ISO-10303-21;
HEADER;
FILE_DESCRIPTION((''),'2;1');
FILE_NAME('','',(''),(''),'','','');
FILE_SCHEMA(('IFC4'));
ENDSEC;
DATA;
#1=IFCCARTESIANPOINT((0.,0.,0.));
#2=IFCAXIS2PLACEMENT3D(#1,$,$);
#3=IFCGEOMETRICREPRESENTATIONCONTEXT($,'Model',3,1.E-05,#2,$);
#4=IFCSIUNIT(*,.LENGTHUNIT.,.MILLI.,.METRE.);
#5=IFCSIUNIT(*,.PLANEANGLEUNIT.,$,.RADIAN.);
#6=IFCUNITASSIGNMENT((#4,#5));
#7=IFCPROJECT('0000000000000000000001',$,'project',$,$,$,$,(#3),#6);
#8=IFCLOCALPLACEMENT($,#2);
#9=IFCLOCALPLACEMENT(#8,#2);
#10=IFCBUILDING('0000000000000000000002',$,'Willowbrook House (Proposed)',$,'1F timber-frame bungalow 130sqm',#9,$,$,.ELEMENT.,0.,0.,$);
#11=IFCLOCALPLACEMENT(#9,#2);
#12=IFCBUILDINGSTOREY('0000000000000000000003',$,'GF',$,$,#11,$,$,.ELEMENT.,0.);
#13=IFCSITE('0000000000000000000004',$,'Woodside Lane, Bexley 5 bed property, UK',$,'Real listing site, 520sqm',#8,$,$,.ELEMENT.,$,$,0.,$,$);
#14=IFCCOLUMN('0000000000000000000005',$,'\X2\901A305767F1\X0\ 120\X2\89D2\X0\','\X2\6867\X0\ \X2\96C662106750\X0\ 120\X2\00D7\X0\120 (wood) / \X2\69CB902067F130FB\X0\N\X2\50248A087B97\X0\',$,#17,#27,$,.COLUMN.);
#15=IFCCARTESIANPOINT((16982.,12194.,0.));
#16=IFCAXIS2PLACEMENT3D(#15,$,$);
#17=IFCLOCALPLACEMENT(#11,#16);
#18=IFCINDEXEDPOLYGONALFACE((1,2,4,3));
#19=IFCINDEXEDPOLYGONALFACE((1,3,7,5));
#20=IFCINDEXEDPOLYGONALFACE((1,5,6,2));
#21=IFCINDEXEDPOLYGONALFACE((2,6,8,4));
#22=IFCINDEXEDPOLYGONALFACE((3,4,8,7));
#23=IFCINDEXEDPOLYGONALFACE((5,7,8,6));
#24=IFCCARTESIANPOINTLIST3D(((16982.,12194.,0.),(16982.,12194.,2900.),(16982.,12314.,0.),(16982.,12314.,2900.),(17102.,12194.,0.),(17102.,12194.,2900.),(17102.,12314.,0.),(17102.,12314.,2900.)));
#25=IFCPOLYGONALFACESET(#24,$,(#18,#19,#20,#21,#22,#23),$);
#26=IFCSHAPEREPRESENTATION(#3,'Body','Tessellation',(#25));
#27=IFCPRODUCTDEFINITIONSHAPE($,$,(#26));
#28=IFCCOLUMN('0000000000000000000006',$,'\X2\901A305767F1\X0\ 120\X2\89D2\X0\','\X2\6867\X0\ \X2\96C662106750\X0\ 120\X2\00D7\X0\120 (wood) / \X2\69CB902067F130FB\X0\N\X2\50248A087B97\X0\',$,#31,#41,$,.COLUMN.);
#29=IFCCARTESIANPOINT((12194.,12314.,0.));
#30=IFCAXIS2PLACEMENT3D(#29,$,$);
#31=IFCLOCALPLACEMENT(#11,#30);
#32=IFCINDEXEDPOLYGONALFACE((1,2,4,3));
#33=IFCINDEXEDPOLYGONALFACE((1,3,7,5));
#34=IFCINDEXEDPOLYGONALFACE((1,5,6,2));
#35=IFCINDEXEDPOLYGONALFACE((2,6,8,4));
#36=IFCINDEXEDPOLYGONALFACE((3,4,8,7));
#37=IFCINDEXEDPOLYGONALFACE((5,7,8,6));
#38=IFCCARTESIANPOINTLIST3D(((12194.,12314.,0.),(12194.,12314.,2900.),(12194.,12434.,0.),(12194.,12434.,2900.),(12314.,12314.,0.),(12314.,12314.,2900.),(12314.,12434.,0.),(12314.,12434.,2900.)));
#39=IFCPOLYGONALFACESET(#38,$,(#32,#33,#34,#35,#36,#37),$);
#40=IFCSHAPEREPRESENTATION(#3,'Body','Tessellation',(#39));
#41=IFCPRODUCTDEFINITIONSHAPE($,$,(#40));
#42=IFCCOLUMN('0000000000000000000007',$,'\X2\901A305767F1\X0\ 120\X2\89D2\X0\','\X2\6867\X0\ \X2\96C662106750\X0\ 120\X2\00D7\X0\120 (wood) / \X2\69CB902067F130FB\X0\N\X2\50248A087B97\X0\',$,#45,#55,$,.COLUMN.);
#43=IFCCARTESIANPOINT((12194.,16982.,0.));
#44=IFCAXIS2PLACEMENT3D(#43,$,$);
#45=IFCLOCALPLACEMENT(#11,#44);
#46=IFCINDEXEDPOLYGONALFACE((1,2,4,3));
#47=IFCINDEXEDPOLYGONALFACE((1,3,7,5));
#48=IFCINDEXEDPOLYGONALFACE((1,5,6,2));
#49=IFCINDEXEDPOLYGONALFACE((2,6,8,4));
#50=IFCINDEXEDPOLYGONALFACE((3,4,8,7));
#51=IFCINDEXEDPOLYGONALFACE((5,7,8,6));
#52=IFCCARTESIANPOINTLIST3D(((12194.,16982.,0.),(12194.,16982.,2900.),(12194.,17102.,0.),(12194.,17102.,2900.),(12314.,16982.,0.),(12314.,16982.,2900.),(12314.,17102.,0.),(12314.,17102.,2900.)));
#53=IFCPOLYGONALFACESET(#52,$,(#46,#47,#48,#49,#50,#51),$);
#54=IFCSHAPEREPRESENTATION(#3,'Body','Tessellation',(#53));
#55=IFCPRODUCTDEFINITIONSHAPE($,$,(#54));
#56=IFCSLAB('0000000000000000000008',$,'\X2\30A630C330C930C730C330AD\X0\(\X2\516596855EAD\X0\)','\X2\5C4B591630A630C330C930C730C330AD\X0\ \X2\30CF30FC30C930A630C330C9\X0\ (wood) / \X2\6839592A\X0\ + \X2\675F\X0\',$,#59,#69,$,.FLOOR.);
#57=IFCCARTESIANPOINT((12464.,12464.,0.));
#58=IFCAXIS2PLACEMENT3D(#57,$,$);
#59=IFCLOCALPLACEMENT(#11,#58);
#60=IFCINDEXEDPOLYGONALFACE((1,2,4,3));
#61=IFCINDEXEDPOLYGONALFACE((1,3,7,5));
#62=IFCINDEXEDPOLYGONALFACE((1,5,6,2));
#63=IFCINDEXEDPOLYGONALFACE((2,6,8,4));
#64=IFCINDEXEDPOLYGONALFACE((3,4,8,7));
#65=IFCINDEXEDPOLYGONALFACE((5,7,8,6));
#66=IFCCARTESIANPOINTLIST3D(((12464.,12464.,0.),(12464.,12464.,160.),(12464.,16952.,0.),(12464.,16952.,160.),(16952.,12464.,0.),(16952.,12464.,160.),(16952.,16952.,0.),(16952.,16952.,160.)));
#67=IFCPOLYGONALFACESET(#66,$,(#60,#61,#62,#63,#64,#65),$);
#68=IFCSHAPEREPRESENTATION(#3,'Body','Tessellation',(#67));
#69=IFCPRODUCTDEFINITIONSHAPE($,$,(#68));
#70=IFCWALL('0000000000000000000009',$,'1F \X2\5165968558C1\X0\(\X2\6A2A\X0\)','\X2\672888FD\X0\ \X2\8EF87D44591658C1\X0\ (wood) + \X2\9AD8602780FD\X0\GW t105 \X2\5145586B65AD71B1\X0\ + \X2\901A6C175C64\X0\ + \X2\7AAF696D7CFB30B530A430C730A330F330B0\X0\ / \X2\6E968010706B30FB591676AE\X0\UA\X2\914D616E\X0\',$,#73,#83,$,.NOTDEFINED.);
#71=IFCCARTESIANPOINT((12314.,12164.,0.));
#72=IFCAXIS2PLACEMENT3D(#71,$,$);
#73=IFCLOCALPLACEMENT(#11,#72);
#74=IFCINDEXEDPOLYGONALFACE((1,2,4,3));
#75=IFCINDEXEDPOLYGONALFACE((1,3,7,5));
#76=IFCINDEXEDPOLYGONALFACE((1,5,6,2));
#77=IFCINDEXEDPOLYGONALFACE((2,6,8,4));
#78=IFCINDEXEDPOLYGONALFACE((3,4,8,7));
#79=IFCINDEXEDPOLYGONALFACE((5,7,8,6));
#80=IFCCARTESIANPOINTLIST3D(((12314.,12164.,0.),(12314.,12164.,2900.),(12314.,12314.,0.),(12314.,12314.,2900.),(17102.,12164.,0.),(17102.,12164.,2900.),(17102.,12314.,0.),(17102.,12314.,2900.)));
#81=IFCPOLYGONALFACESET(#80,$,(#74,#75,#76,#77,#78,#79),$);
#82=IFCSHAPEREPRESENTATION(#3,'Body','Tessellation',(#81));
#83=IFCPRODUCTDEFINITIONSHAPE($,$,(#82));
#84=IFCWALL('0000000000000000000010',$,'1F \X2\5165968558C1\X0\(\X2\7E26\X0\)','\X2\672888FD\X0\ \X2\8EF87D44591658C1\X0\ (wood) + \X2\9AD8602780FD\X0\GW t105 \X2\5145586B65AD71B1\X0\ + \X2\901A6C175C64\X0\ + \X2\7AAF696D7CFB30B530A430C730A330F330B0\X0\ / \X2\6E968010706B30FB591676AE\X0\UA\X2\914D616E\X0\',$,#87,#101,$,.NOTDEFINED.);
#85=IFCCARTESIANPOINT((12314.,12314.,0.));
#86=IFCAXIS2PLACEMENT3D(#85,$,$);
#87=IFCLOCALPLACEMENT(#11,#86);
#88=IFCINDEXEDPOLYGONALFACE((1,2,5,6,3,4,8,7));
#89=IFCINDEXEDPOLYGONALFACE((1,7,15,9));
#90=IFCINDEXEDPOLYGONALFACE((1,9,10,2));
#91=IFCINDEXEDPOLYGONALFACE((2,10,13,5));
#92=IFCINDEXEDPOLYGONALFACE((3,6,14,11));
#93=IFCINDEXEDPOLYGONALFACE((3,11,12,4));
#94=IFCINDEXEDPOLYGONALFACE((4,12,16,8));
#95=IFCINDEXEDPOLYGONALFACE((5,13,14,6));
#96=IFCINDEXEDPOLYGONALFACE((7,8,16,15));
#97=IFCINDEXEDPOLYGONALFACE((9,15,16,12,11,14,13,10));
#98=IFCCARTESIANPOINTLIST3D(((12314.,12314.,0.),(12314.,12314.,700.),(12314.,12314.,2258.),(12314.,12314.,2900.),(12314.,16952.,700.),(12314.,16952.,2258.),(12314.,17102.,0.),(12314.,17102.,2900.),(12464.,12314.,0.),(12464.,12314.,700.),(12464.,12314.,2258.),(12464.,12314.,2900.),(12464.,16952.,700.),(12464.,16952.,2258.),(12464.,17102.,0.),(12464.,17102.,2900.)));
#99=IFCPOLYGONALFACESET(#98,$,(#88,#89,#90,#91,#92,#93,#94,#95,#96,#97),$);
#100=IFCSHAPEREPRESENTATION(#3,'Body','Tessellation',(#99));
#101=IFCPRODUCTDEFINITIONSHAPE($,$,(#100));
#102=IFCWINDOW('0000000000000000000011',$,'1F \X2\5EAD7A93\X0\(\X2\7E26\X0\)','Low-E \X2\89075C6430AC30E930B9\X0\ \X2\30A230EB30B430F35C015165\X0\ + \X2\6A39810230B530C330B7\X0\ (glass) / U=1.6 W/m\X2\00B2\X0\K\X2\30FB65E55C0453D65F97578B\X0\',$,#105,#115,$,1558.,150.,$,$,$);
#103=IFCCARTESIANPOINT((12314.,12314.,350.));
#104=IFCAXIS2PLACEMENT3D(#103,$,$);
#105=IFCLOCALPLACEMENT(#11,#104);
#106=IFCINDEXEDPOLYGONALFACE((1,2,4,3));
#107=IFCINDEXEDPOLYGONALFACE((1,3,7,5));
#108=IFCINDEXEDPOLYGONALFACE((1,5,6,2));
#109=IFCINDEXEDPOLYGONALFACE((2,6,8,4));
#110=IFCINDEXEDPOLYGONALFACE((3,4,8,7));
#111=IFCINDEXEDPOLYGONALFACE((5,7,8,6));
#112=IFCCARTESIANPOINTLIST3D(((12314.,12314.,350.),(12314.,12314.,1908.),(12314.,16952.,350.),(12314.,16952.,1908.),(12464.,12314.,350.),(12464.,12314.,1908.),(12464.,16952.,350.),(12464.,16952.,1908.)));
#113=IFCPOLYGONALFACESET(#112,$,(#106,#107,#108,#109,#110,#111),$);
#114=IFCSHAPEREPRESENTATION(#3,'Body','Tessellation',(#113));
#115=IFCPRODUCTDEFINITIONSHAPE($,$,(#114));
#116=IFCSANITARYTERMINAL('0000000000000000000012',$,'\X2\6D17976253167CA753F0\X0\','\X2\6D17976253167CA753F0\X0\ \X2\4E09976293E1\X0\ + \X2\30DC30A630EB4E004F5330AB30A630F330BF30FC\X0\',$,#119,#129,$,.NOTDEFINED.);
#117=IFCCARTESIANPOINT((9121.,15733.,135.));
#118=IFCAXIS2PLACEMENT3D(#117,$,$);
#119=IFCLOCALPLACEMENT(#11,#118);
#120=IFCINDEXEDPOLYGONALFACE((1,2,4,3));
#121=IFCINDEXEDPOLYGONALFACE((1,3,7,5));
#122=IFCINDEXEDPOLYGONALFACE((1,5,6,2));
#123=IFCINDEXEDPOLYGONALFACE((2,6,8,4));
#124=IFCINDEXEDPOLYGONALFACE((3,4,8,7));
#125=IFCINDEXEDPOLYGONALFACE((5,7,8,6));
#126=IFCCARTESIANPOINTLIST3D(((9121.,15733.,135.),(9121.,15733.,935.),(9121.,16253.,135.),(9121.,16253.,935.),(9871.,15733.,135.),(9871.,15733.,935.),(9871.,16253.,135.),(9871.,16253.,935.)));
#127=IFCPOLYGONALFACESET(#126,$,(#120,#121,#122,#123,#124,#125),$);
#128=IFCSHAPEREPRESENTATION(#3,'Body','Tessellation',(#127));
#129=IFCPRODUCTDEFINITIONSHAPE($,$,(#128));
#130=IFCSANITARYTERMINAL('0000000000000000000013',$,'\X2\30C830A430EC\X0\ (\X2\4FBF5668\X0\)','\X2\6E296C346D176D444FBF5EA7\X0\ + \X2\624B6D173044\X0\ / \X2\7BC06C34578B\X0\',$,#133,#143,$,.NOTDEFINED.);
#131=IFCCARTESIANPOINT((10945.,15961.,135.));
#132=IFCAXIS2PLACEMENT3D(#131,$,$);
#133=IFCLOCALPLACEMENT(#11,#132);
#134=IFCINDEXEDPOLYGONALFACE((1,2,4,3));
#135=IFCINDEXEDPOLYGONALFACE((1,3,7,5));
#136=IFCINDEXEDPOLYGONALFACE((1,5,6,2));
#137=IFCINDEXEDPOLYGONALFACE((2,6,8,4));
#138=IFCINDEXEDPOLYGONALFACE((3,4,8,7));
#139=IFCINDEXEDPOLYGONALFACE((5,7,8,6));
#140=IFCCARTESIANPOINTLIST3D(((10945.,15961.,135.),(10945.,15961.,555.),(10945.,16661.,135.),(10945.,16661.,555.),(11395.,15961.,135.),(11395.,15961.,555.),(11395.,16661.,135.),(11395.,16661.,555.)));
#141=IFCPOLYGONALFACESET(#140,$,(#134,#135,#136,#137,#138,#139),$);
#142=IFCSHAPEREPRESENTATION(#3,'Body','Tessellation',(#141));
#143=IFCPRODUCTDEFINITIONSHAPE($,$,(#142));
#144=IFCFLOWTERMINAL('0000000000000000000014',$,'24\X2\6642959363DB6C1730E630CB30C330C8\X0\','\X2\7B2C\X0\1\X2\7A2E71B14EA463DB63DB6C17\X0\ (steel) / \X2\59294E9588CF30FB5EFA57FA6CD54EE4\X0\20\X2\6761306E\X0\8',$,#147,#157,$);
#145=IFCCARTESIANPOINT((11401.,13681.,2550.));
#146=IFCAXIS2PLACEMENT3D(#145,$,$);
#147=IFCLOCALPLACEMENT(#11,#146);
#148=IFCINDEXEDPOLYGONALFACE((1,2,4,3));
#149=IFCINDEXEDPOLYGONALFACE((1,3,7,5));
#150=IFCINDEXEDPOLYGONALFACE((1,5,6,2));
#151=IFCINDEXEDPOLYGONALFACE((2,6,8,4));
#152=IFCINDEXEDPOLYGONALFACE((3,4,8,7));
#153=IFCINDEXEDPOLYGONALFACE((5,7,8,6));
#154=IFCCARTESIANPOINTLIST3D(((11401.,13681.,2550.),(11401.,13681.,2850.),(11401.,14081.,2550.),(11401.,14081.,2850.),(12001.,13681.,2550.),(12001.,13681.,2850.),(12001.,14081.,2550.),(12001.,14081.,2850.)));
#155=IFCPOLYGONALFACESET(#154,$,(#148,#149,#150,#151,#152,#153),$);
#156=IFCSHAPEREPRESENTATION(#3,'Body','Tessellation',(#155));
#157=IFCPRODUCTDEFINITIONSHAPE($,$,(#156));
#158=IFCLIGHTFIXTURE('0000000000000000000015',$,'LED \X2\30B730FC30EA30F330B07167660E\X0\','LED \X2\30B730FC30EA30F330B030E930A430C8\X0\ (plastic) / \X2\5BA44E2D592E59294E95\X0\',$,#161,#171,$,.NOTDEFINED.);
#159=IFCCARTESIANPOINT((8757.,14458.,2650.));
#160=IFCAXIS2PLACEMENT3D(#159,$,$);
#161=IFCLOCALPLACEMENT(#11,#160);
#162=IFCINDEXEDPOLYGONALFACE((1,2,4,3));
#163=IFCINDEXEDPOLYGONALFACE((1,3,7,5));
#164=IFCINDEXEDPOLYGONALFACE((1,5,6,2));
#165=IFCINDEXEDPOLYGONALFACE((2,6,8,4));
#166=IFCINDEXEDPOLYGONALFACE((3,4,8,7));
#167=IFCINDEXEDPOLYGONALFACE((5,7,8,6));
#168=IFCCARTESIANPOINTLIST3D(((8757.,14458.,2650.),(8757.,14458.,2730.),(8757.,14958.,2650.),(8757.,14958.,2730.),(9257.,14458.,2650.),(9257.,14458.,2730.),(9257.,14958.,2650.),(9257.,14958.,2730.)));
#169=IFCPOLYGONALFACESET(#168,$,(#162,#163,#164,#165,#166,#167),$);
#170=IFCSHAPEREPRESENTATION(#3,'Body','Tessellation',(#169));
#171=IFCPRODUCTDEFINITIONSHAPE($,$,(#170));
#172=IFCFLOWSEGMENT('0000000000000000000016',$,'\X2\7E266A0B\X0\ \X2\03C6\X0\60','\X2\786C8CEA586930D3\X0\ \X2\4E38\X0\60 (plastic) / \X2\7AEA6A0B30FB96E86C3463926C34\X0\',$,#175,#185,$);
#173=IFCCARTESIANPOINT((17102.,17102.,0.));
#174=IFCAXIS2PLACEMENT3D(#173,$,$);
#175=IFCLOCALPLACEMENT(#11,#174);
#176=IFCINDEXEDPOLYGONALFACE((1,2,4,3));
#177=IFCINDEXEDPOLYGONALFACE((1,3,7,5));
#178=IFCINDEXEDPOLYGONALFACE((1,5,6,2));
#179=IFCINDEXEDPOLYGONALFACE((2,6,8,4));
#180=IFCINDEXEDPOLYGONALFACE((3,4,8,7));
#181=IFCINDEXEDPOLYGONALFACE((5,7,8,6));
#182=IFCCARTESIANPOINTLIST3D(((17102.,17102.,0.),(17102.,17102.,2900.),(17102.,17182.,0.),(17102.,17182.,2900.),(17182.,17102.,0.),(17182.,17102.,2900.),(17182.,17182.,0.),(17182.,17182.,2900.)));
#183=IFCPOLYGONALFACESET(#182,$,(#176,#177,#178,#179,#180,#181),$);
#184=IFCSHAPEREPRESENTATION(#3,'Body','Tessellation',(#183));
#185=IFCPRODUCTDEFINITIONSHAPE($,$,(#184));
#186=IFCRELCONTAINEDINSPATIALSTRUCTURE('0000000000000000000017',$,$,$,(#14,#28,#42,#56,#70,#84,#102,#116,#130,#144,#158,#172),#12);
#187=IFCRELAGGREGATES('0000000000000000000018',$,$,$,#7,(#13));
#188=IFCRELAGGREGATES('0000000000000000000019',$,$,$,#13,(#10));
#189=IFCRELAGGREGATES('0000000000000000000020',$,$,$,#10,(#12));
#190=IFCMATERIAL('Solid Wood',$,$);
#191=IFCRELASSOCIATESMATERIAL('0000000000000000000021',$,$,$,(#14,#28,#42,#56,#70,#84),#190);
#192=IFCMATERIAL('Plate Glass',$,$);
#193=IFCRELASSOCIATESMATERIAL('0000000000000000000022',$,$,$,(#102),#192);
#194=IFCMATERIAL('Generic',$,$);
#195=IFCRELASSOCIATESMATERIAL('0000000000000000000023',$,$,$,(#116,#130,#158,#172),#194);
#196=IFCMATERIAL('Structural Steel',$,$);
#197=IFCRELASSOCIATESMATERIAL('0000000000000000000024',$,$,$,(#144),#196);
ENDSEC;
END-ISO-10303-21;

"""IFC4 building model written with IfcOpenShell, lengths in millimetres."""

from ifc_helpers import new_model, si_unit, frame, frame_2d, origin, place, context, project, spatial, rectangle, extrude, material, element, fill, save


model = new_model("IFC4")

# Units and contexts
model_context = context("Model", 3, precision=1e-05, world=origin())
ifc_project = project(units=[si_unit("LENGTHUNIT", "METRE", prefix="MILLI"), si_unit("PLANEANGLEUNIT", "RADIAN")], contexts=[model_context])

# Site, building, storey
site_placement = place(None, origin())
site = spatial("IfcSite", under=ifc_project, at=site_placement, Name="Woodside Lane, Bexley 5 bed property, UK", ObjectType="Real listing site, 520sqm", CompositionType="ELEMENT", RefElevation=0.0)
building_placement = place(site_placement, origin())
building = spatial("IfcBuilding", under=site, at=building_placement, Name="Willowbrook House (Proposed)", ObjectType="1F timber-frame bungalow 130sqm", CompositionType="ELEMENT", ElevationOfRefHeight=0.0, ElevationOfTerrain=0.0)
storey_placement = place(building_placement, origin())
storey = spatial("IfcBuildingStorey", under=building, at=storey_placement, Name="GF", CompositionType="ELEMENT", Elevation=0.0)

# Columns
ifc_material_1 = material(Name="Solid Wood")
column_1_placement = place(storey_placement, frame((16982.0, 12194.0, 0.0)))
element("IfcColumn", 1, at=column_1_placement, inside=storey, material=ifc_material_1, Name="通し柱 120角", Description="桧 集成材 120×120 (wood) / 構造柱・N値計算", PredefinedType="COLUMN", context=model_context, shape_type="SweptSolid", body=[
    extrude(rectangle(XDim=120.0, YDim=120.0, at=frame_2d((60.0, 60.0))), frame((16982.0, 12194.0, 0.0)), (0.0, 0.0, 1.0), 2900.0),
])
column_2_placement = place(storey_placement, frame((12194.0, 12314.0, 0.0)))
element("IfcColumn", 2, at=column_2_placement, inside=storey, material=ifc_material_1, Name="通し柱 120角", Description="桧 集成材 120×120 (wood) / 構造柱・N値計算", PredefinedType="COLUMN", context=model_context, shape_type="SweptSolid", body=[
    extrude(rectangle(XDim=120.0, YDim=120.0, at=frame_2d((60.0, 60.0))), frame((12194.0, 12314.0, 0.0)), (0.0, 0.0, 1.0), 2900.0),
])
column_3_placement = place(storey_placement, frame((12194.0, 16982.0, 0.0)))
element("IfcColumn", 3, at=column_3_placement, inside=storey, material=ifc_material_1, Name="通し柱 120角", Description="桧 集成材 120×120 (wood) / 構造柱・N値計算", PredefinedType="COLUMN", context=model_context, shape_type="SweptSolid", body=[
    extrude(rectangle(XDim=120.0, YDim=120.0, at=frame_2d((60.0, 60.0))), frame((12194.0, 16982.0, 0.0)), (0.0, 0.0, 1.0), 2900.0),
])

# Slab
slab_placement = place(storey_placement, frame((12464.0, 12464.0, 0.0)))
element("IfcSlab", 4, at=slab_placement, inside=storey, material=ifc_material_1, Name="ウッドデッキ(入隅庭)", Description="屋外ウッドデッキ ハードウッド (wood) / 根太 + 束", PredefinedType="FLOOR", context=model_context, shape_type="SweptSolid", body=[
    extrude(rectangle(XDim=4488.0, YDim=4488.0, at=frame_2d((2244.0, 2244.0))), frame((12464.0, 12464.0, 0.0)), (0.0, 0.0, 1.0), 160.0),
])

# Wall
wall_1_placement = place(storey_placement, frame((12314.0, 12164.0, 0.0)))
element("IfcWall", 5, at=wall_1_placement, inside=storey, material=ifc_material_1, Name="1F 入隅壁(横)", Description="木製 軸組外壁 (wood) + 高性能GW t105 充填断熱 + 通気層 + 窯業系サイディング / 準耐火・外皮UA配慮", PredefinedType="NOTDEFINED", context=model_context, shape_type="SweptSolid", body=[
    extrude(rectangle(XDim=4788.0, YDim=150.0, at=frame_2d((2394.0, 75.0))), frame((12314.0, 12164.0, 0.0)), (0.0, 0.0, 1.0), 2900.0),
])

# Wall, opening, window
wall_2_placement = place(storey_placement, frame((12314.0, 12314.0, 0.0)))
wall_2 = element("IfcWall", 6, at=wall_2_placement, inside=storey, material=ifc_material_1, Name="1F 入隅壁(縦)", Description="木製 軸組外壁 (wood) + 高性能GW t105 充填断熱 + 通気層 + 窯業系サイディング / 準耐火・外皮UA配慮", PredefinedType="NOTDEFINED", context=model_context, shape_type="SweptSolid", body=[
    extrude(rectangle(XDim=150.0, YDim=4788.0, at=frame_2d((75.0, 2394.0))), frame((12314.0, 12314.0, 0.0)), (0.0, 0.0, 1.0), 2900.0),
])
opening_placement = place(storey_placement, frame((12314.0, 12314.0, 350.0)))
opening = element("IfcOpeningElement", 7, at=opening_placement, cuts=wall_2, PredefinedType="NOTDEFINED", context=model_context, shape_type="SweptSolid", body=[
    extrude(rectangle(XDim=150.0, YDim=4638.0, at=frame_2d((75.0, 2319.0))), frame((12314.0, 12314.0, 350.0)), (0.0, 0.0, 1.0), 1558.0),
])
ifc_material_2 = material(Name="Plate Glass")
window_placement = place(storey_placement, frame((12314.0, 12314.0, 350.0)))
window = element("IfcWindow", 8, at=window_placement, inside=storey, material=ifc_material_2, Name="1F 庭窓(縦)", Description="Low-E 複層ガラス アルゴン封入 + 樹脂サッシ (glass) / U=1.6 W/m²K・日射取得型", OverallHeight=1558.0, OverallWidth=150.0, context=model_context, shape_type="SweptSolid", body=[
    extrude(rectangle(XDim=150.0, YDim=4638.0, at=frame_2d((75.0, 2319.0))), frame((12314.0, 12314.0, 350.0)), (0.0, 0.0, 1.0), 1558.0),
])
fill(opening, window)

# Sanitary terminals
ifc_material_3 = material(Name="Generic")
sanitary_terminal_1_placement = place(storey_placement, frame((9121.0, 15733.0, 135.0)))
element("IfcSanitaryTerminal", 9, at=sanitary_terminal_1_placement, inside=storey, material=ifc_material_3, Name="洗面化粧台", Description="洗面化粧台 三面鏡 + ボウル一体カウンター", PredefinedType="NOTDEFINED", context=model_context, shape_type="SweptSolid", body=[
    extrude(rectangle(XDim=750.0, YDim=520.0, at=frame_2d((375.0, 260.0))), frame((9121.0, 15733.0, 135.0)), (0.0, 0.0, 1.0), 800.0),
])
sanitary_terminal_2_placement = place(storey_placement, frame((10945.0, 15961.0, 135.0)))
element("IfcSanitaryTerminal", 10, at=sanitary_terminal_2_placement, inside=storey, material=ifc_material_3, Name="トイレ (便器)", Description="温水洗浄便座 + 手洗い / 節水型", PredefinedType="NOTDEFINED", context=model_context, shape_type="SweptSolid", body=[
    extrude(rectangle(XDim=450.0, YDim=700.0, at=frame_2d((225.0, 350.0))), frame((10945.0, 15961.0, 135.0)), (0.0, 0.0, 1.0), 420.0),
])

# Flow terminal
ifc_material_4 = material(Name="Structural Steel")
flow_terminal_placement = place(storey_placement, frame((11401.0, 13681.0, 2550.0)))
element("IfcFlowTerminal", 11, at=flow_terminal_placement, inside=storey, material=ifc_material_4, Name="24時間換気ユニット", Description="第1種熱交換換気 (steel) / 天井裏・建基法令20条の8", context=model_context, shape_type="SweptSolid", body=[
    extrude(rectangle(XDim=600.0, YDim=400.0, at=frame_2d((300.0, 200.0))), frame((11401.0, 13681.0, 2550.0)), (0.0, 0.0, 1.0), 300.0),
])

# Light fixture
light_fixture_placement = place(storey_placement, frame((8757.0, 14458.0, 2650.0)))
element("IfcLightFixture", 12, at=light_fixture_placement, inside=storey, material=ifc_material_3, Name="LED シーリング照明", Description="LED シーリングライト (plastic) / 室中央天井", PredefinedType="NOTDEFINED", context=model_context, shape_type="SweptSolid", body=[
    extrude(rectangle(XDim=500.0, YDim=500.0, at=frame_2d((250.0, 250.0))), frame((8757.0, 14458.0, 2650.0)), (0.0, 0.0, 1.0), 80.0),
])

# Flow segment
flow_segment_placement = place(storey_placement, frame((17102.0, 17102.0, 0.0)))
element("IfcFlowSegment", 13, at=flow_segment_placement, inside=storey, material=ifc_material_3, Name="縦樋 φ60", Description="硬質塩ビ 丸60 (plastic) / 竪樋・雨水排水", context=model_context, shape_type="SweptSolid", body=[
    extrude(rectangle(XDim=80.0, YDim=80.0, at=frame_2d((40.0, 40.0))), frame((17102.0, 17102.0, 0.0)), (0.0, 0.0, 1.0), 2900.0),
])

save(model, "model.ifc")
